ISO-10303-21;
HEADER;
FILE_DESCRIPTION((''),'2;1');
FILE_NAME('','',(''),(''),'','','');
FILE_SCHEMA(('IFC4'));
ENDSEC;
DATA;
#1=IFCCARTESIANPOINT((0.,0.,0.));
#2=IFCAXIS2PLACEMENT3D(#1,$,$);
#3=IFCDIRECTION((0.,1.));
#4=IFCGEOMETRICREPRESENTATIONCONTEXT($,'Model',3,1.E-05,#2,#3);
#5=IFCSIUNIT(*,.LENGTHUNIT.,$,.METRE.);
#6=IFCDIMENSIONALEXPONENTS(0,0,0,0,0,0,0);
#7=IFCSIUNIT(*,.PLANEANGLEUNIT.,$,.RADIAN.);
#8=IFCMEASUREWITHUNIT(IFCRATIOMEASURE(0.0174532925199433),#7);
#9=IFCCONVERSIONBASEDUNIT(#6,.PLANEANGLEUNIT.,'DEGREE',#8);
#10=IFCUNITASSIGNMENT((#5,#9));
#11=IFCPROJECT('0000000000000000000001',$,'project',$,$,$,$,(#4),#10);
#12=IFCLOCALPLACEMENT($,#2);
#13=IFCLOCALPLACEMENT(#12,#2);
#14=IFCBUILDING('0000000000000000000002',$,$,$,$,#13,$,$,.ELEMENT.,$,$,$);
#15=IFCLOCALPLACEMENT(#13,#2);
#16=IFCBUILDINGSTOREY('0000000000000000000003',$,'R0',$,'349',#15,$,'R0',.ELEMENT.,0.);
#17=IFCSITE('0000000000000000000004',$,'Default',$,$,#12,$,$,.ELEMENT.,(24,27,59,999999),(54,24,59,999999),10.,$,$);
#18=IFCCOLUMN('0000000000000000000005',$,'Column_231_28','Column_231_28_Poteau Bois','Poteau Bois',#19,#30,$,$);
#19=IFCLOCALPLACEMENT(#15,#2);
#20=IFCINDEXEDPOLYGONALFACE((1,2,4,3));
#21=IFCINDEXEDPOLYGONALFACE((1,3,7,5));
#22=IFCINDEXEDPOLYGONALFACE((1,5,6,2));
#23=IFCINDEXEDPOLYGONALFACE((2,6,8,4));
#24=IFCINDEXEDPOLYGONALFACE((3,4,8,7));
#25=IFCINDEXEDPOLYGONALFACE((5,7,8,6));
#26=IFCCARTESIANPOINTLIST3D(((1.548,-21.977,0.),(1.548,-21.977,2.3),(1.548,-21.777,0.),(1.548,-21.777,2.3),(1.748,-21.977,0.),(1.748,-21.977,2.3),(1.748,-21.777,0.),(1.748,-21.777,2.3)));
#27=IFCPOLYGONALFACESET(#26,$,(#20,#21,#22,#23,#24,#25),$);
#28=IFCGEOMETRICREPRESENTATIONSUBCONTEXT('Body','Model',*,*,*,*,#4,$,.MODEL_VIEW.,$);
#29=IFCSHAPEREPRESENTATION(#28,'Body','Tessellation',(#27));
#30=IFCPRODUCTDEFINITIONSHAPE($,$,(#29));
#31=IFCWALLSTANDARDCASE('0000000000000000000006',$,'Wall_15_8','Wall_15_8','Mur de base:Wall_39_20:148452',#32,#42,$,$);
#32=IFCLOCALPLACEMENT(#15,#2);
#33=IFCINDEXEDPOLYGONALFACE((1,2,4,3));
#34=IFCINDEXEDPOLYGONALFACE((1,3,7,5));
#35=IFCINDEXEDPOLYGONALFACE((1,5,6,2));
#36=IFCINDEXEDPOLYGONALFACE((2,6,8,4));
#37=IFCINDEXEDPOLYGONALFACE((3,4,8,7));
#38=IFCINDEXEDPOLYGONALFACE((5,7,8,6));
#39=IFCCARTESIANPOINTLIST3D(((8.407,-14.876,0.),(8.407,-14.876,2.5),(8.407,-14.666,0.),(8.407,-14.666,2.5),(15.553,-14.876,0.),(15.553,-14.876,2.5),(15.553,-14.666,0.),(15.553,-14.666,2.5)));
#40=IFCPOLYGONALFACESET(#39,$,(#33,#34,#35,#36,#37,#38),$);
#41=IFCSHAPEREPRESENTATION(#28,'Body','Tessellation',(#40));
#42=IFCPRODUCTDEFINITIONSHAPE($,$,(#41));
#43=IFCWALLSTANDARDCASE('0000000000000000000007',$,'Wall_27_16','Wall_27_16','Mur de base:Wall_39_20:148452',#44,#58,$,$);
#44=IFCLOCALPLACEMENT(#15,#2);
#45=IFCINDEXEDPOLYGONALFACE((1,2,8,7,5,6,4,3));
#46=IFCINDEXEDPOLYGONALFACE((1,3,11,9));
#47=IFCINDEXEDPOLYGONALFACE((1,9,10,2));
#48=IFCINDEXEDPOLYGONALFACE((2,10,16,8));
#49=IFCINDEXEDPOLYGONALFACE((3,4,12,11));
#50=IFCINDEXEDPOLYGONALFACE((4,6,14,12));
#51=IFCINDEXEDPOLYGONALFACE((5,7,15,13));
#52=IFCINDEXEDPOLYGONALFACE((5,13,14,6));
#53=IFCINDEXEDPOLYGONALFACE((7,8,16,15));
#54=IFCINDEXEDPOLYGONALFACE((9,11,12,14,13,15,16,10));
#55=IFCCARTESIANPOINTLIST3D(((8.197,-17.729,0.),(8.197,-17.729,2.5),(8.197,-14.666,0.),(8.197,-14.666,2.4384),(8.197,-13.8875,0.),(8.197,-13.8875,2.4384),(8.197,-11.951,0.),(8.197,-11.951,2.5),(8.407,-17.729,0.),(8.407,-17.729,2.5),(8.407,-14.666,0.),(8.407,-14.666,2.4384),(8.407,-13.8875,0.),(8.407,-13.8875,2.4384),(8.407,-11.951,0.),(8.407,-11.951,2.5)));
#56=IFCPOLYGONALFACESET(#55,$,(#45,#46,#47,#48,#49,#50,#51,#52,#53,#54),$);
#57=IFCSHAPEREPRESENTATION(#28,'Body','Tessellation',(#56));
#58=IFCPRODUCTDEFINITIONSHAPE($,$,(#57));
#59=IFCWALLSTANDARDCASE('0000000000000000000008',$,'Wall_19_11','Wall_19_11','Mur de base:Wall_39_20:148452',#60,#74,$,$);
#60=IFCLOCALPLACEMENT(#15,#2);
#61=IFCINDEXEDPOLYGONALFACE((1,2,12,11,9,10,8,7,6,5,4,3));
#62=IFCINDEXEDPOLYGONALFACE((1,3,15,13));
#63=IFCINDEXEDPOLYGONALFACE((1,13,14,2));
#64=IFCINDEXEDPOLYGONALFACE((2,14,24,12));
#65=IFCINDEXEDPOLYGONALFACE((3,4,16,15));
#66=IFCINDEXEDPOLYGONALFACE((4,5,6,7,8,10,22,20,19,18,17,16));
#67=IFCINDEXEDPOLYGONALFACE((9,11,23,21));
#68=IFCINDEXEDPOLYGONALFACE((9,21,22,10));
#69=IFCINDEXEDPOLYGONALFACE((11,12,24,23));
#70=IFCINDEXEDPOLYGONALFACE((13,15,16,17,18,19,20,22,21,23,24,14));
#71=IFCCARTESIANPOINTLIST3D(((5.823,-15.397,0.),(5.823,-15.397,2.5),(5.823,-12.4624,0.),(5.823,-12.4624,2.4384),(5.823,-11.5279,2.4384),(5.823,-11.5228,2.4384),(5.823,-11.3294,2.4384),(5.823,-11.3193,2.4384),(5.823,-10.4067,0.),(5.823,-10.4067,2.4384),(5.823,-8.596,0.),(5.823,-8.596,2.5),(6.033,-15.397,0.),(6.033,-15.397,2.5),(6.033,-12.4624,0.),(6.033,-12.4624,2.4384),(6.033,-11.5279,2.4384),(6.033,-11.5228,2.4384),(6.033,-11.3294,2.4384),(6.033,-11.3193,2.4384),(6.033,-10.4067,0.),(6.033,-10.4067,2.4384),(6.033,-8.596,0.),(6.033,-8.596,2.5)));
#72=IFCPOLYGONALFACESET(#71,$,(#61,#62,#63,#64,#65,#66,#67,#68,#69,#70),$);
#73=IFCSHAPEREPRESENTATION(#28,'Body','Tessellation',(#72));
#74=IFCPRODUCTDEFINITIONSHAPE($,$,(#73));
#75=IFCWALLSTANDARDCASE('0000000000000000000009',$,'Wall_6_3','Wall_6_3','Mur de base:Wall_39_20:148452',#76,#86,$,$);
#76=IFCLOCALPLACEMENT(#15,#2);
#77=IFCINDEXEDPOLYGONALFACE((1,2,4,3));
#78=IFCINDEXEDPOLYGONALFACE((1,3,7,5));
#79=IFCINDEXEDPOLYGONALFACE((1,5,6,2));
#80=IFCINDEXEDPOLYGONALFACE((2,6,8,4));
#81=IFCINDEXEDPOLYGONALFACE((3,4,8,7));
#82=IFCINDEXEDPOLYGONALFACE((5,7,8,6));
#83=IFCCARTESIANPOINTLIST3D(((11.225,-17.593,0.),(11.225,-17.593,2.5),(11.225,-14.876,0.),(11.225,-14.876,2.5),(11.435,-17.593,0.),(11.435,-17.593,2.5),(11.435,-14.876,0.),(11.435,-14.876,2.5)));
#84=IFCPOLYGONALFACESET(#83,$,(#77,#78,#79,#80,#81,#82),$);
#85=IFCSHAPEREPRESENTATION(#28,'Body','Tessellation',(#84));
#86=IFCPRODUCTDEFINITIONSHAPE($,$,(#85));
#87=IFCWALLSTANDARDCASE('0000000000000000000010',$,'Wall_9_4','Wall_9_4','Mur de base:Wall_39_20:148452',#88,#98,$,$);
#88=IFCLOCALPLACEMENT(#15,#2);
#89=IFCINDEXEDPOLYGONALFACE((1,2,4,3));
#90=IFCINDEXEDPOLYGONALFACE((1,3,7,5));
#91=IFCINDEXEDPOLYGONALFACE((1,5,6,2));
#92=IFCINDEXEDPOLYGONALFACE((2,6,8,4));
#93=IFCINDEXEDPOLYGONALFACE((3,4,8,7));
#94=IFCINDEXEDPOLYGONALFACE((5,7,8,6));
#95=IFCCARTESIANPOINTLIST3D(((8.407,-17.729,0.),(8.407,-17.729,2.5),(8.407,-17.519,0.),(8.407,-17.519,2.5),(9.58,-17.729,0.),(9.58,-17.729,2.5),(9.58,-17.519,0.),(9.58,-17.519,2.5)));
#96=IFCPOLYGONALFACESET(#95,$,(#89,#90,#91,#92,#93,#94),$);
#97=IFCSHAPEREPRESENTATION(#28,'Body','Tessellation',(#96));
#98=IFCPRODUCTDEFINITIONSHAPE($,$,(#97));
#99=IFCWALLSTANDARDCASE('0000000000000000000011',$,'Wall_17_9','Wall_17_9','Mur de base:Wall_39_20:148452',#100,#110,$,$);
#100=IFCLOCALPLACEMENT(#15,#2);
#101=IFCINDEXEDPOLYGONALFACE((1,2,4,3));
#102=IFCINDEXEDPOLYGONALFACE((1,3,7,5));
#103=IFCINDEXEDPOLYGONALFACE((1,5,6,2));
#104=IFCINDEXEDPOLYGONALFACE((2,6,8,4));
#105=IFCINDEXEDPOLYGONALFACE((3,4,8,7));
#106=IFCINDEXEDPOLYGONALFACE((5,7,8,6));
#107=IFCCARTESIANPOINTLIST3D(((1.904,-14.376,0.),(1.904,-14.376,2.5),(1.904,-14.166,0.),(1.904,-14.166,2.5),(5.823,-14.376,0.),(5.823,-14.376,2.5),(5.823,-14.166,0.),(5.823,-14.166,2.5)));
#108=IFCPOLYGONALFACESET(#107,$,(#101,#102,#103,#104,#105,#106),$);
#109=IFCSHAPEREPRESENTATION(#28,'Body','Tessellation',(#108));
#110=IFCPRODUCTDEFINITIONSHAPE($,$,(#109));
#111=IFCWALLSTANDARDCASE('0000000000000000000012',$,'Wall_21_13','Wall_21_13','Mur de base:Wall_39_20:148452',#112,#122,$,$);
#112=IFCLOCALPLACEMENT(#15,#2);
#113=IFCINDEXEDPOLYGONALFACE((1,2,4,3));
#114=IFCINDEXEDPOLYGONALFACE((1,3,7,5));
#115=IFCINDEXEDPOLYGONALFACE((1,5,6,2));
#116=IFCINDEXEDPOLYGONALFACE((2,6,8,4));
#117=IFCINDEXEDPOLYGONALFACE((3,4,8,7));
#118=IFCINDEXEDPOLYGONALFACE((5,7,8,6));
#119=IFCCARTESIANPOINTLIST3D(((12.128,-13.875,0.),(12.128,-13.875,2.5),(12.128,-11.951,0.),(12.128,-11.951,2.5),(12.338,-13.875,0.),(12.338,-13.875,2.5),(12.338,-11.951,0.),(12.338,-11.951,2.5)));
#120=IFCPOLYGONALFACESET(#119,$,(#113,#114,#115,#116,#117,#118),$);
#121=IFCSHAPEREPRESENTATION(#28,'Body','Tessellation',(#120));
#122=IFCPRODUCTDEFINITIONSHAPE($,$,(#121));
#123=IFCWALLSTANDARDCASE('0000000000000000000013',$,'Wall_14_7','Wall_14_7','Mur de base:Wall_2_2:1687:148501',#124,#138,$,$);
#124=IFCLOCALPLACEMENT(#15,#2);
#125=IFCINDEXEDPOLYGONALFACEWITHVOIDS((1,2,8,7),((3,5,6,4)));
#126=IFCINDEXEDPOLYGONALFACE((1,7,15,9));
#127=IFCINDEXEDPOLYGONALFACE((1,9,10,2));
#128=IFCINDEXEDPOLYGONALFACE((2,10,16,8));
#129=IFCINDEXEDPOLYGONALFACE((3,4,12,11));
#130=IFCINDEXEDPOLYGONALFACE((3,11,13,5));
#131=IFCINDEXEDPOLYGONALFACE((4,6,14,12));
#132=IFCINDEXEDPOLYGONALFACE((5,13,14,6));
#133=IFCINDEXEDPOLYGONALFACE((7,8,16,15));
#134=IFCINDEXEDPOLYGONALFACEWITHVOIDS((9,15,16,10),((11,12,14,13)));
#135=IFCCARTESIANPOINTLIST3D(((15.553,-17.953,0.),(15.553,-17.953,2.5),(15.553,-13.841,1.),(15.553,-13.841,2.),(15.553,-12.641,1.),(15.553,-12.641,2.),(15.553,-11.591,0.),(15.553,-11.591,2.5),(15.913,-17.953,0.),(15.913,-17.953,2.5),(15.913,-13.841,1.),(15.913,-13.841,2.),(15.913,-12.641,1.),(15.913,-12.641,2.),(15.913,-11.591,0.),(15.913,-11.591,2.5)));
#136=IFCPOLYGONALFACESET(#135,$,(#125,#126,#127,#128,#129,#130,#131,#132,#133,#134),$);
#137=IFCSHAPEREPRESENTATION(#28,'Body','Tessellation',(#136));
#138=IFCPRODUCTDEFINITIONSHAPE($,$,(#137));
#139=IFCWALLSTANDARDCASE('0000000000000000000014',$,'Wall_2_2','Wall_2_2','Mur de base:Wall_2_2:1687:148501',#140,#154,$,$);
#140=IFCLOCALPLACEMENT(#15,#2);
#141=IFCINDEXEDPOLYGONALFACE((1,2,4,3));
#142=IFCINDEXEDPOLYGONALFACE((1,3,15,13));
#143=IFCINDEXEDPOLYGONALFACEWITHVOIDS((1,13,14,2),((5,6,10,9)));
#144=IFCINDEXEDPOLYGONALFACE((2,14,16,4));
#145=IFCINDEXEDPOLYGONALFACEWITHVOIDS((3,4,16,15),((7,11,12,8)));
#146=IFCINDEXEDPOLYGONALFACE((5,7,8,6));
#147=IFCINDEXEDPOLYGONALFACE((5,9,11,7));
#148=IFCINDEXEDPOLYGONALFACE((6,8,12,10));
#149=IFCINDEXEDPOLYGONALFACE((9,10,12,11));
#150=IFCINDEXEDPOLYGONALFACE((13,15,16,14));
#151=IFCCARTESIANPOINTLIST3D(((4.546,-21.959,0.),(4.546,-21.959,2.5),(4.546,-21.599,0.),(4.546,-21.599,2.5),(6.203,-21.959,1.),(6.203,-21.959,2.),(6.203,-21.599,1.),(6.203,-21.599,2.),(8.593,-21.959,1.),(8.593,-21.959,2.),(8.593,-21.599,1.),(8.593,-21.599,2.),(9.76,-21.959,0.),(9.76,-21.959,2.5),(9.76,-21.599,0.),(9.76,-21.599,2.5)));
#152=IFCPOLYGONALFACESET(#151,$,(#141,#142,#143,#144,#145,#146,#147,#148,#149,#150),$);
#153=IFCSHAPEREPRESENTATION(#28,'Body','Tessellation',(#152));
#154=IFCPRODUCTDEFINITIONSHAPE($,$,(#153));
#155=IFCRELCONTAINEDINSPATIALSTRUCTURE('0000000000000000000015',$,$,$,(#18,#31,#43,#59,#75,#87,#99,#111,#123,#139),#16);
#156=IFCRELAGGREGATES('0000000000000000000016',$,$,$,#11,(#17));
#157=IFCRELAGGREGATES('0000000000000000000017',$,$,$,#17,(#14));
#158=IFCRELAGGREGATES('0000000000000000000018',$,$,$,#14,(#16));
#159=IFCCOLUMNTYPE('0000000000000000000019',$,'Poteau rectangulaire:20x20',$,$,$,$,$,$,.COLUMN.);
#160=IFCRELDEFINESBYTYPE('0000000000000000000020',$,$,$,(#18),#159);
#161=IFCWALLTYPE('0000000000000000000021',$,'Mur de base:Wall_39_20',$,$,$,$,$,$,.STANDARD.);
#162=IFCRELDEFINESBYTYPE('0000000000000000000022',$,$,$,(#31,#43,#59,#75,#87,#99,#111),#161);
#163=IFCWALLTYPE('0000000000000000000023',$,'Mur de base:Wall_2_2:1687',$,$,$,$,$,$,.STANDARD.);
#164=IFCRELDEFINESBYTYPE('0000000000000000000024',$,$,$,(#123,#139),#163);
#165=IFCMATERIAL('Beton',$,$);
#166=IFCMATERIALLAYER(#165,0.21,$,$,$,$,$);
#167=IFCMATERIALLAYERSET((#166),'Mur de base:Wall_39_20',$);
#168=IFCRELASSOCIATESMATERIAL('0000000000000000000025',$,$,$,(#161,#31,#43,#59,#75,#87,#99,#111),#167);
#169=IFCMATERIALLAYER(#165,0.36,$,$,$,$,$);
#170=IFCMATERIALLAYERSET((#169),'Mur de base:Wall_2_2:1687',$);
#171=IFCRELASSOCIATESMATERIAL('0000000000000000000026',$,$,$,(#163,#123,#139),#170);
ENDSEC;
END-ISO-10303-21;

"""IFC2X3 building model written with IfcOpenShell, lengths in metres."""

from ifc_helpers import new_model, entity, si_unit, converted_unit, direction, frame, frame_2d, origin, origin_2d_with_axis, place, context, subcontext, project, spatial, rectangle, extrude, source, transform, mapped, material, layer, layer_set, layer_usage, type_object, type_shapes, element, save


model = new_model("IFC2X3")

# Units and contexts
model_context = context("Model", 3, precision=1e-05, world=origin(), true_north=direction((0.0, 1.0)))
body_context = subcontext(model_context, "Body", "Model", "MODEL_VIEW")
ifc_project = project(units=[si_unit("LENGTHUNIT", "METRE"), converted_unit("PLANEANGLEUNIT", "DEGREE", entity("IfcRatioMeasure", 0.0174532925199433), si_unit("PLANEANGLEUNIT", "RADIAN"), dimensions=[0, 0, 0, 0, 0, 0, 0])], contexts=[model_context])

# Site, building, storey
site_placement = place(None, origin())
site = spatial("IfcSite", under=ifc_project, at=site_placement, Name="Default", CompositionType="ELEMENT", RefLatitude=(24, 27, 59, 999999), RefLongitude=(54, 24, 59, 999999), RefElevation=10.0)
building_placement = place(site_placement, origin())
building = spatial("IfcBuilding", under=site, at=building_placement, CompositionType="ELEMENT")
storey_placement = place(building_placement, origin())
storey = spatial("IfcBuildingStorey", under=building, at=storey_placement, Name="R0", ObjectType="349", LongName="R0", CompositionType="ELEMENT", Elevation=0.0)

# Column
column_type = type_object("IfcColumnType", Name="Poteau rectangulaire:20x20", PredefinedType="COLUMN")
shared_shape_1 = source(origin(), body_context, "Body", "SweptSolid", [
    extrude(rectangle(XDim=0.2, YDim=0.2, at=origin_2d_with_axis()), frame((0.0, 0.0, 0.0), z_axis=(0.0, 0.0, 1.0), x_axis=(-1.0, 0.0, 0.0)), (0.0, 0.0, 1.0), 2.3),
])
type_shapes(column_type, [shared_shape_1])
column_placement = place(storey_placement, frame((1.648, -21.877, 0.0), z_axis=(0.0, 0.0, 1.0), x_axis=(0.0, 1.0, 0.0)))
element("IfcColumn", 1, at=column_placement, inside=storey, type_object=column_type, Name="Column_231_28", Description="Column_231_28_Poteau Bois", ObjectType="Poteau Bois", context=body_context, shape_type="MappedRepresentation", body=[
    mapped(shared_shape_1, transform((0.0, 0.0, 0.0), scale=1.0)),
])

# Wall
ifc_material_1 = material(Name="Beton")
ifc_layer_1 = layer(ifc_material_1, 0.21)
ifc_layer_set_1 = layer_set([ifc_layer_1], Name="Mur de base:Wall_39_20")
ifc_layer_usage_1 = layer_usage(ifc_layer_set_1, "AXIS2", "NEGATIVE", 0.105)
wall_type_1 = type_object("IfcWallType", Name="Mur de base:Wall_39_20", PredefinedType="STANDARD", material=ifc_layer_set_1)
wall_1_placement = place(storey_placement, frame((8.407, -14.771, 0.0)))
element("IfcWallStandardCase", 2, at=wall_1_placement, inside=storey, type_object=wall_type_1, material=ifc_layer_usage_1, Name="Wall_15_8", Description="Wall_15_8", ObjectType="Mur de base:Wall_39_20:148452", context=body_context, shape_type="SweptSolid", body=[
    extrude(rectangle(XDim=7.146, YDim=0.21, at=frame_2d((3.573, 0.0), x_axis=(-1.0, 0.0))), origin(), (0.0, 0.0, 1.0), 2.5),
])

# Wall, opening
ifc_layer_usage_2 = layer_usage(ifc_layer_set_1, "AXIS2", "NEGATIVE", 0.105)
wall_2_placement = place(storey_placement, frame((8.302, -17.729, 0.0), z_axis=(0.0, 0.0, 1.0), x_axis=(0.0, 1.0, 0.0)))
wall_2 = element("IfcWallStandardCase", 3, at=wall_2_placement, inside=storey, type_object=wall_type_1, material=ifc_layer_usage_2, Name="Wall_27_16", Description="Wall_27_16", ObjectType="Mur de base:Wall_39_20:148452", context=body_context, shape_type="SweptSolid", body=[
    extrude(rectangle(XDim=5.778, YDim=0.21, at=frame_2d((2.889, 0.0), x_axis=(-1.0, 0.0))), origin(), (0.0, 0.0, 1.0), 2.5),
])
opening_1_placement = place(wall_2_placement, origin())
element("IfcOpeningElement", 4, at=opening_1_placement, cuts=wall_2, ObjectType="Opening", context=body_context, shape_type="SweptSolid", body=[
    extrude(rectangle(XDim=2.4384, YDim=0.7785, at=frame_2d((0.0, 0.0), x_axis=(1.0, 0.0))), frame((3.4522, -0.105, 1.2192), z_axis=(0.0, 1.0, 0.0), x_axis=(0.0, 0.0, -1.0)), (0.0, 0.0, 1.0), 0.21),
])

# Wall, openings
ifc_layer_usage_3 = layer_usage(ifc_layer_set_1, "AXIS2", "NEGATIVE", 0.105)
wall_3_placement = place(storey_placement, frame((5.928, -15.397, 0.0), z_axis=(0.0, 0.0, 1.0), x_axis=(0.0, 1.0, 0.0)))
wall_3 = element("IfcWallStandardCase", 5, at=wall_3_placement, inside=storey, type_object=wall_type_1, material=ifc_layer_usage_3, Name="Wall_19_11", Description="Wall_19_11", ObjectType="Mur de base:Wall_39_20:148452", context=body_context, shape_type="SweptSolid", body=[
    extrude(rectangle(XDim=6.801, YDim=0.21, at=frame_2d((3.4005, 0.0), x_axis=(-1.0, 0.0))), origin(), (0.0, 0.0, 1.0), 2.5),
])
opening_2_placement = place(wall_3_placement, origin())
element("IfcOpeningElement", 6, at=opening_2_placement, cuts=wall_3, ObjectType="Opening", context=body_context, shape_type="SweptSolid", body=[
    extrude(rectangle(XDim=2.4384, YDim=0.0102, at=origin_2d_with_axis()), frame((4.0727, -0.105, 1.2192), z_axis=(0.0, 1.0, 0.0), x_axis=(0.0, 0.0, -1.0)), (0.0, 0.0, 1.0), 0.21),
])
opening_3_placement = place(wall_3_placement, origin())
element("IfcOpeningElement", 7, at=opening_3_placement, cuts=wall_3, ObjectType="Opening", context=body_context, shape_type="SweptSolid", body=[
    extrude(rectangle(XDim=2.4384, YDim=0.0051, at=frame_2d((0.0, 0.0), x_axis=(1.0, 0.0))), frame((3.8716, -0.105, 1.2192), z_axis=(0.0, 1.0, 0.0), x_axis=(0.0, 0.0, -1.0)), (0.0, 0.0, 1.0), 0.21),
])
opening_4_placement = place(wall_3_placement, origin())
element("IfcOpeningElement", 8, at=opening_4_placement, cuts=wall_3, ObjectType="Opening", context=body_context, shape_type="SweptSolid", body=[
    extrude(rectangle(XDim=2.4384, YDim=2.0557, at=origin_2d_with_axis()), frame((3.9625, -0.105, 1.2192), z_axis=(0.0, 1.0, 0.0), x_axis=(0.0, 0.0, -1.0)), (0.0, 0.0, 1.0), 0.21),
])

# Walls
ifc_layer_usage_4 = layer_usage(ifc_layer_set_1, "AXIS2", "NEGATIVE", 0.105)
wall_4_placement = place(storey_placement, frame((11.33, -17.593, 0.0), z_axis=(0.0, 0.0, 1.0), x_axis=(0.0, 1.0, 0.0)))
element("IfcWallStandardCase", 9, at=wall_4_placement, inside=storey, type_object=wall_type_1, material=ifc_layer_usage_4, Name="Wall_6_3", Description="Wall_6_3", ObjectType="Mur de base:Wall_39_20:148452", context=body_context, shape_type="SweptSolid", body=[
    extrude(rectangle(XDim=2.717, YDim=0.21, at=frame_2d((1.3585, 0.0), x_axis=(-1.0, 0.0))), origin(), (0.0, 0.0, 1.0), 2.5),
])
ifc_layer_usage_5 = layer_usage(ifc_layer_set_1, "AXIS2", "NEGATIVE", 0.105)
wall_5_placement = place(storey_placement, frame((8.407, -17.624, 0.0)))
element("IfcWallStandardCase", 10, at=wall_5_placement, inside=storey, type_object=wall_type_1, material=ifc_layer_usage_5, Name="Wall_9_4", Description="Wall_9_4", ObjectType="Mur de base:Wall_39_20:148452", context=body_context, shape_type="SweptSolid", body=[
    extrude(rectangle(XDim=1.173, YDim=0.21, at=frame_2d((0.5865, 0.0), x_axis=(-1.0, 0.0))), origin(), (0.0, 0.0, 1.0), 2.5),
])
ifc_layer_usage_6 = layer_usage(ifc_layer_set_1, "AXIS2", "NEGATIVE", 0.105)
wall_6_placement = place(storey_placement, frame((1.904, -14.271, 0.0)))
element("IfcWallStandardCase", 11, at=wall_6_placement, inside=storey, type_object=wall_type_1, material=ifc_layer_usage_6, Name="Wall_17_9", Description="Wall_17_9", ObjectType="Mur de base:Wall_39_20:148452", context=body_context, shape_type="SweptSolid", body=[
    extrude(rectangle(XDim=3.919, YDim=0.21, at=frame_2d((1.9595, 0.0), x_axis=(-1.0, 0.0))), origin(), (0.0, 0.0, 1.0), 2.5),
])
ifc_layer_usage_7 = layer_usage(ifc_layer_set_1, "AXIS2", "NEGATIVE", 0.105)
wall_7_placement = place(storey_placement, frame((12.233, -13.875, 0.0), z_axis=(0.0, 0.0, 1.0), x_axis=(0.0, 1.0, 0.0)))
element("IfcWallStandardCase", 12, at=wall_7_placement, inside=storey, type_object=wall_type_1, material=ifc_layer_usage_7, Name="Wall_21_13", Description="Wall_21_13", ObjectType="Mur de base:Wall_39_20:148452", context=body_context, shape_type="SweptSolid", body=[
    extrude(rectangle(XDim=1.924, YDim=0.21, at=frame_2d((0.962, 0.0), x_axis=(-1.0, 0.0))), origin(), (0.0, 0.0, 1.0), 2.5),
])

# Shared definitions
ifc_layer_2 = layer(ifc_material_1, 0.36)
ifc_layer_set_2 = layer_set([ifc_layer_2], Name="Mur de base:Wall_2_2:1687")
wall_type_2 = type_object("IfcWallType", Name="Mur de base:Wall_2_2:1687", PredefinedType="STANDARD", material=ifc_layer_set_2)

# Wall, opening
ifc_layer_usage_8 = layer_usage(ifc_layer_set_2, "AXIS2", "NEGATIVE", 0.18)
wall_8_placement = place(storey_placement, frame((15.733, -17.953, 0.0), z_axis=(0.0, 0.0, 1.0), x_axis=(0.0, 1.0, 0.0)))
wall_8 = element("IfcWallStandardCase", 13, at=wall_8_placement, inside=storey, type_object=wall_type_2, material=ifc_layer_usage_8, Name="Wall_14_7", Description="Wall_14_7", ObjectType="Mur de base:Wall_2_2:1687:148501", context=body_context, shape_type="SweptSolid", body=[
    extrude(rectangle(XDim=6.362, YDim=0.36, at=frame_2d((3.181, 0.0), x_axis=(-1.0, 0.0))), origin(), (0.0, 0.0, 1.0), 2.5),
])
opening_5_placement = place(wall_8_placement, origin())
element("IfcOpeningElement", 14, at=opening_5_placement, cuts=wall_8, ObjectType="Opening", context=body_context, shape_type="SweptSolid", body=[
    extrude(rectangle(XDim=1.0, YDim=1.2, at=frame_2d((0.0, 0.0), x_axis=(1.0, 0.0))), frame((4.712, -0.19, 1.5), z_axis=(0.0, 1.0, 0.0), x_axis=(0.0, 0.0, -1.0)), (0.0, 0.0, 1.0), 0.38),
])

# Wall, opening
ifc_layer_usage_9 = layer_usage(ifc_layer_set_2, "AXIS2", "NEGATIVE", 0.18)
wall_9_placement = place(storey_placement, frame((4.546, -21.779, 0.0)))
wall_9 = element("IfcWallStandardCase", 15, at=wall_9_placement, inside=storey, type_object=wall_type_2, material=ifc_layer_usage_9, Name="Wall_2_2", Description="Wall_2_2", ObjectType="Mur de base:Wall_2_2:1687:148501", context=body_context, shape_type="SweptSolid", body=[
    extrude(rectangle(XDim=5.214, YDim=0.36, at=frame_2d((2.607, 0.0), x_axis=(-1.0, 0.0))), origin(), (0.0, 0.0, 1.0), 2.5),
])
opening_6_placement = place(wall_9_placement, origin())
element("IfcOpeningElement", 16, at=opening_6_placement, cuts=wall_9, ObjectType="Opening", context=body_context, shape_type="SweptSolid", body=[
    extrude(rectangle(XDim=1.0, YDim=2.39, at=frame_2d((0.0, 0.0), x_axis=(1.0, 0.0))), frame((2.852, -0.19, 1.5), z_axis=(0.0, 1.0, 0.0), x_axis=(0.0, 0.0, -1.0)), (0.0, 0.0, 1.0), 0.38),
])

save(model, "model.ifc")
